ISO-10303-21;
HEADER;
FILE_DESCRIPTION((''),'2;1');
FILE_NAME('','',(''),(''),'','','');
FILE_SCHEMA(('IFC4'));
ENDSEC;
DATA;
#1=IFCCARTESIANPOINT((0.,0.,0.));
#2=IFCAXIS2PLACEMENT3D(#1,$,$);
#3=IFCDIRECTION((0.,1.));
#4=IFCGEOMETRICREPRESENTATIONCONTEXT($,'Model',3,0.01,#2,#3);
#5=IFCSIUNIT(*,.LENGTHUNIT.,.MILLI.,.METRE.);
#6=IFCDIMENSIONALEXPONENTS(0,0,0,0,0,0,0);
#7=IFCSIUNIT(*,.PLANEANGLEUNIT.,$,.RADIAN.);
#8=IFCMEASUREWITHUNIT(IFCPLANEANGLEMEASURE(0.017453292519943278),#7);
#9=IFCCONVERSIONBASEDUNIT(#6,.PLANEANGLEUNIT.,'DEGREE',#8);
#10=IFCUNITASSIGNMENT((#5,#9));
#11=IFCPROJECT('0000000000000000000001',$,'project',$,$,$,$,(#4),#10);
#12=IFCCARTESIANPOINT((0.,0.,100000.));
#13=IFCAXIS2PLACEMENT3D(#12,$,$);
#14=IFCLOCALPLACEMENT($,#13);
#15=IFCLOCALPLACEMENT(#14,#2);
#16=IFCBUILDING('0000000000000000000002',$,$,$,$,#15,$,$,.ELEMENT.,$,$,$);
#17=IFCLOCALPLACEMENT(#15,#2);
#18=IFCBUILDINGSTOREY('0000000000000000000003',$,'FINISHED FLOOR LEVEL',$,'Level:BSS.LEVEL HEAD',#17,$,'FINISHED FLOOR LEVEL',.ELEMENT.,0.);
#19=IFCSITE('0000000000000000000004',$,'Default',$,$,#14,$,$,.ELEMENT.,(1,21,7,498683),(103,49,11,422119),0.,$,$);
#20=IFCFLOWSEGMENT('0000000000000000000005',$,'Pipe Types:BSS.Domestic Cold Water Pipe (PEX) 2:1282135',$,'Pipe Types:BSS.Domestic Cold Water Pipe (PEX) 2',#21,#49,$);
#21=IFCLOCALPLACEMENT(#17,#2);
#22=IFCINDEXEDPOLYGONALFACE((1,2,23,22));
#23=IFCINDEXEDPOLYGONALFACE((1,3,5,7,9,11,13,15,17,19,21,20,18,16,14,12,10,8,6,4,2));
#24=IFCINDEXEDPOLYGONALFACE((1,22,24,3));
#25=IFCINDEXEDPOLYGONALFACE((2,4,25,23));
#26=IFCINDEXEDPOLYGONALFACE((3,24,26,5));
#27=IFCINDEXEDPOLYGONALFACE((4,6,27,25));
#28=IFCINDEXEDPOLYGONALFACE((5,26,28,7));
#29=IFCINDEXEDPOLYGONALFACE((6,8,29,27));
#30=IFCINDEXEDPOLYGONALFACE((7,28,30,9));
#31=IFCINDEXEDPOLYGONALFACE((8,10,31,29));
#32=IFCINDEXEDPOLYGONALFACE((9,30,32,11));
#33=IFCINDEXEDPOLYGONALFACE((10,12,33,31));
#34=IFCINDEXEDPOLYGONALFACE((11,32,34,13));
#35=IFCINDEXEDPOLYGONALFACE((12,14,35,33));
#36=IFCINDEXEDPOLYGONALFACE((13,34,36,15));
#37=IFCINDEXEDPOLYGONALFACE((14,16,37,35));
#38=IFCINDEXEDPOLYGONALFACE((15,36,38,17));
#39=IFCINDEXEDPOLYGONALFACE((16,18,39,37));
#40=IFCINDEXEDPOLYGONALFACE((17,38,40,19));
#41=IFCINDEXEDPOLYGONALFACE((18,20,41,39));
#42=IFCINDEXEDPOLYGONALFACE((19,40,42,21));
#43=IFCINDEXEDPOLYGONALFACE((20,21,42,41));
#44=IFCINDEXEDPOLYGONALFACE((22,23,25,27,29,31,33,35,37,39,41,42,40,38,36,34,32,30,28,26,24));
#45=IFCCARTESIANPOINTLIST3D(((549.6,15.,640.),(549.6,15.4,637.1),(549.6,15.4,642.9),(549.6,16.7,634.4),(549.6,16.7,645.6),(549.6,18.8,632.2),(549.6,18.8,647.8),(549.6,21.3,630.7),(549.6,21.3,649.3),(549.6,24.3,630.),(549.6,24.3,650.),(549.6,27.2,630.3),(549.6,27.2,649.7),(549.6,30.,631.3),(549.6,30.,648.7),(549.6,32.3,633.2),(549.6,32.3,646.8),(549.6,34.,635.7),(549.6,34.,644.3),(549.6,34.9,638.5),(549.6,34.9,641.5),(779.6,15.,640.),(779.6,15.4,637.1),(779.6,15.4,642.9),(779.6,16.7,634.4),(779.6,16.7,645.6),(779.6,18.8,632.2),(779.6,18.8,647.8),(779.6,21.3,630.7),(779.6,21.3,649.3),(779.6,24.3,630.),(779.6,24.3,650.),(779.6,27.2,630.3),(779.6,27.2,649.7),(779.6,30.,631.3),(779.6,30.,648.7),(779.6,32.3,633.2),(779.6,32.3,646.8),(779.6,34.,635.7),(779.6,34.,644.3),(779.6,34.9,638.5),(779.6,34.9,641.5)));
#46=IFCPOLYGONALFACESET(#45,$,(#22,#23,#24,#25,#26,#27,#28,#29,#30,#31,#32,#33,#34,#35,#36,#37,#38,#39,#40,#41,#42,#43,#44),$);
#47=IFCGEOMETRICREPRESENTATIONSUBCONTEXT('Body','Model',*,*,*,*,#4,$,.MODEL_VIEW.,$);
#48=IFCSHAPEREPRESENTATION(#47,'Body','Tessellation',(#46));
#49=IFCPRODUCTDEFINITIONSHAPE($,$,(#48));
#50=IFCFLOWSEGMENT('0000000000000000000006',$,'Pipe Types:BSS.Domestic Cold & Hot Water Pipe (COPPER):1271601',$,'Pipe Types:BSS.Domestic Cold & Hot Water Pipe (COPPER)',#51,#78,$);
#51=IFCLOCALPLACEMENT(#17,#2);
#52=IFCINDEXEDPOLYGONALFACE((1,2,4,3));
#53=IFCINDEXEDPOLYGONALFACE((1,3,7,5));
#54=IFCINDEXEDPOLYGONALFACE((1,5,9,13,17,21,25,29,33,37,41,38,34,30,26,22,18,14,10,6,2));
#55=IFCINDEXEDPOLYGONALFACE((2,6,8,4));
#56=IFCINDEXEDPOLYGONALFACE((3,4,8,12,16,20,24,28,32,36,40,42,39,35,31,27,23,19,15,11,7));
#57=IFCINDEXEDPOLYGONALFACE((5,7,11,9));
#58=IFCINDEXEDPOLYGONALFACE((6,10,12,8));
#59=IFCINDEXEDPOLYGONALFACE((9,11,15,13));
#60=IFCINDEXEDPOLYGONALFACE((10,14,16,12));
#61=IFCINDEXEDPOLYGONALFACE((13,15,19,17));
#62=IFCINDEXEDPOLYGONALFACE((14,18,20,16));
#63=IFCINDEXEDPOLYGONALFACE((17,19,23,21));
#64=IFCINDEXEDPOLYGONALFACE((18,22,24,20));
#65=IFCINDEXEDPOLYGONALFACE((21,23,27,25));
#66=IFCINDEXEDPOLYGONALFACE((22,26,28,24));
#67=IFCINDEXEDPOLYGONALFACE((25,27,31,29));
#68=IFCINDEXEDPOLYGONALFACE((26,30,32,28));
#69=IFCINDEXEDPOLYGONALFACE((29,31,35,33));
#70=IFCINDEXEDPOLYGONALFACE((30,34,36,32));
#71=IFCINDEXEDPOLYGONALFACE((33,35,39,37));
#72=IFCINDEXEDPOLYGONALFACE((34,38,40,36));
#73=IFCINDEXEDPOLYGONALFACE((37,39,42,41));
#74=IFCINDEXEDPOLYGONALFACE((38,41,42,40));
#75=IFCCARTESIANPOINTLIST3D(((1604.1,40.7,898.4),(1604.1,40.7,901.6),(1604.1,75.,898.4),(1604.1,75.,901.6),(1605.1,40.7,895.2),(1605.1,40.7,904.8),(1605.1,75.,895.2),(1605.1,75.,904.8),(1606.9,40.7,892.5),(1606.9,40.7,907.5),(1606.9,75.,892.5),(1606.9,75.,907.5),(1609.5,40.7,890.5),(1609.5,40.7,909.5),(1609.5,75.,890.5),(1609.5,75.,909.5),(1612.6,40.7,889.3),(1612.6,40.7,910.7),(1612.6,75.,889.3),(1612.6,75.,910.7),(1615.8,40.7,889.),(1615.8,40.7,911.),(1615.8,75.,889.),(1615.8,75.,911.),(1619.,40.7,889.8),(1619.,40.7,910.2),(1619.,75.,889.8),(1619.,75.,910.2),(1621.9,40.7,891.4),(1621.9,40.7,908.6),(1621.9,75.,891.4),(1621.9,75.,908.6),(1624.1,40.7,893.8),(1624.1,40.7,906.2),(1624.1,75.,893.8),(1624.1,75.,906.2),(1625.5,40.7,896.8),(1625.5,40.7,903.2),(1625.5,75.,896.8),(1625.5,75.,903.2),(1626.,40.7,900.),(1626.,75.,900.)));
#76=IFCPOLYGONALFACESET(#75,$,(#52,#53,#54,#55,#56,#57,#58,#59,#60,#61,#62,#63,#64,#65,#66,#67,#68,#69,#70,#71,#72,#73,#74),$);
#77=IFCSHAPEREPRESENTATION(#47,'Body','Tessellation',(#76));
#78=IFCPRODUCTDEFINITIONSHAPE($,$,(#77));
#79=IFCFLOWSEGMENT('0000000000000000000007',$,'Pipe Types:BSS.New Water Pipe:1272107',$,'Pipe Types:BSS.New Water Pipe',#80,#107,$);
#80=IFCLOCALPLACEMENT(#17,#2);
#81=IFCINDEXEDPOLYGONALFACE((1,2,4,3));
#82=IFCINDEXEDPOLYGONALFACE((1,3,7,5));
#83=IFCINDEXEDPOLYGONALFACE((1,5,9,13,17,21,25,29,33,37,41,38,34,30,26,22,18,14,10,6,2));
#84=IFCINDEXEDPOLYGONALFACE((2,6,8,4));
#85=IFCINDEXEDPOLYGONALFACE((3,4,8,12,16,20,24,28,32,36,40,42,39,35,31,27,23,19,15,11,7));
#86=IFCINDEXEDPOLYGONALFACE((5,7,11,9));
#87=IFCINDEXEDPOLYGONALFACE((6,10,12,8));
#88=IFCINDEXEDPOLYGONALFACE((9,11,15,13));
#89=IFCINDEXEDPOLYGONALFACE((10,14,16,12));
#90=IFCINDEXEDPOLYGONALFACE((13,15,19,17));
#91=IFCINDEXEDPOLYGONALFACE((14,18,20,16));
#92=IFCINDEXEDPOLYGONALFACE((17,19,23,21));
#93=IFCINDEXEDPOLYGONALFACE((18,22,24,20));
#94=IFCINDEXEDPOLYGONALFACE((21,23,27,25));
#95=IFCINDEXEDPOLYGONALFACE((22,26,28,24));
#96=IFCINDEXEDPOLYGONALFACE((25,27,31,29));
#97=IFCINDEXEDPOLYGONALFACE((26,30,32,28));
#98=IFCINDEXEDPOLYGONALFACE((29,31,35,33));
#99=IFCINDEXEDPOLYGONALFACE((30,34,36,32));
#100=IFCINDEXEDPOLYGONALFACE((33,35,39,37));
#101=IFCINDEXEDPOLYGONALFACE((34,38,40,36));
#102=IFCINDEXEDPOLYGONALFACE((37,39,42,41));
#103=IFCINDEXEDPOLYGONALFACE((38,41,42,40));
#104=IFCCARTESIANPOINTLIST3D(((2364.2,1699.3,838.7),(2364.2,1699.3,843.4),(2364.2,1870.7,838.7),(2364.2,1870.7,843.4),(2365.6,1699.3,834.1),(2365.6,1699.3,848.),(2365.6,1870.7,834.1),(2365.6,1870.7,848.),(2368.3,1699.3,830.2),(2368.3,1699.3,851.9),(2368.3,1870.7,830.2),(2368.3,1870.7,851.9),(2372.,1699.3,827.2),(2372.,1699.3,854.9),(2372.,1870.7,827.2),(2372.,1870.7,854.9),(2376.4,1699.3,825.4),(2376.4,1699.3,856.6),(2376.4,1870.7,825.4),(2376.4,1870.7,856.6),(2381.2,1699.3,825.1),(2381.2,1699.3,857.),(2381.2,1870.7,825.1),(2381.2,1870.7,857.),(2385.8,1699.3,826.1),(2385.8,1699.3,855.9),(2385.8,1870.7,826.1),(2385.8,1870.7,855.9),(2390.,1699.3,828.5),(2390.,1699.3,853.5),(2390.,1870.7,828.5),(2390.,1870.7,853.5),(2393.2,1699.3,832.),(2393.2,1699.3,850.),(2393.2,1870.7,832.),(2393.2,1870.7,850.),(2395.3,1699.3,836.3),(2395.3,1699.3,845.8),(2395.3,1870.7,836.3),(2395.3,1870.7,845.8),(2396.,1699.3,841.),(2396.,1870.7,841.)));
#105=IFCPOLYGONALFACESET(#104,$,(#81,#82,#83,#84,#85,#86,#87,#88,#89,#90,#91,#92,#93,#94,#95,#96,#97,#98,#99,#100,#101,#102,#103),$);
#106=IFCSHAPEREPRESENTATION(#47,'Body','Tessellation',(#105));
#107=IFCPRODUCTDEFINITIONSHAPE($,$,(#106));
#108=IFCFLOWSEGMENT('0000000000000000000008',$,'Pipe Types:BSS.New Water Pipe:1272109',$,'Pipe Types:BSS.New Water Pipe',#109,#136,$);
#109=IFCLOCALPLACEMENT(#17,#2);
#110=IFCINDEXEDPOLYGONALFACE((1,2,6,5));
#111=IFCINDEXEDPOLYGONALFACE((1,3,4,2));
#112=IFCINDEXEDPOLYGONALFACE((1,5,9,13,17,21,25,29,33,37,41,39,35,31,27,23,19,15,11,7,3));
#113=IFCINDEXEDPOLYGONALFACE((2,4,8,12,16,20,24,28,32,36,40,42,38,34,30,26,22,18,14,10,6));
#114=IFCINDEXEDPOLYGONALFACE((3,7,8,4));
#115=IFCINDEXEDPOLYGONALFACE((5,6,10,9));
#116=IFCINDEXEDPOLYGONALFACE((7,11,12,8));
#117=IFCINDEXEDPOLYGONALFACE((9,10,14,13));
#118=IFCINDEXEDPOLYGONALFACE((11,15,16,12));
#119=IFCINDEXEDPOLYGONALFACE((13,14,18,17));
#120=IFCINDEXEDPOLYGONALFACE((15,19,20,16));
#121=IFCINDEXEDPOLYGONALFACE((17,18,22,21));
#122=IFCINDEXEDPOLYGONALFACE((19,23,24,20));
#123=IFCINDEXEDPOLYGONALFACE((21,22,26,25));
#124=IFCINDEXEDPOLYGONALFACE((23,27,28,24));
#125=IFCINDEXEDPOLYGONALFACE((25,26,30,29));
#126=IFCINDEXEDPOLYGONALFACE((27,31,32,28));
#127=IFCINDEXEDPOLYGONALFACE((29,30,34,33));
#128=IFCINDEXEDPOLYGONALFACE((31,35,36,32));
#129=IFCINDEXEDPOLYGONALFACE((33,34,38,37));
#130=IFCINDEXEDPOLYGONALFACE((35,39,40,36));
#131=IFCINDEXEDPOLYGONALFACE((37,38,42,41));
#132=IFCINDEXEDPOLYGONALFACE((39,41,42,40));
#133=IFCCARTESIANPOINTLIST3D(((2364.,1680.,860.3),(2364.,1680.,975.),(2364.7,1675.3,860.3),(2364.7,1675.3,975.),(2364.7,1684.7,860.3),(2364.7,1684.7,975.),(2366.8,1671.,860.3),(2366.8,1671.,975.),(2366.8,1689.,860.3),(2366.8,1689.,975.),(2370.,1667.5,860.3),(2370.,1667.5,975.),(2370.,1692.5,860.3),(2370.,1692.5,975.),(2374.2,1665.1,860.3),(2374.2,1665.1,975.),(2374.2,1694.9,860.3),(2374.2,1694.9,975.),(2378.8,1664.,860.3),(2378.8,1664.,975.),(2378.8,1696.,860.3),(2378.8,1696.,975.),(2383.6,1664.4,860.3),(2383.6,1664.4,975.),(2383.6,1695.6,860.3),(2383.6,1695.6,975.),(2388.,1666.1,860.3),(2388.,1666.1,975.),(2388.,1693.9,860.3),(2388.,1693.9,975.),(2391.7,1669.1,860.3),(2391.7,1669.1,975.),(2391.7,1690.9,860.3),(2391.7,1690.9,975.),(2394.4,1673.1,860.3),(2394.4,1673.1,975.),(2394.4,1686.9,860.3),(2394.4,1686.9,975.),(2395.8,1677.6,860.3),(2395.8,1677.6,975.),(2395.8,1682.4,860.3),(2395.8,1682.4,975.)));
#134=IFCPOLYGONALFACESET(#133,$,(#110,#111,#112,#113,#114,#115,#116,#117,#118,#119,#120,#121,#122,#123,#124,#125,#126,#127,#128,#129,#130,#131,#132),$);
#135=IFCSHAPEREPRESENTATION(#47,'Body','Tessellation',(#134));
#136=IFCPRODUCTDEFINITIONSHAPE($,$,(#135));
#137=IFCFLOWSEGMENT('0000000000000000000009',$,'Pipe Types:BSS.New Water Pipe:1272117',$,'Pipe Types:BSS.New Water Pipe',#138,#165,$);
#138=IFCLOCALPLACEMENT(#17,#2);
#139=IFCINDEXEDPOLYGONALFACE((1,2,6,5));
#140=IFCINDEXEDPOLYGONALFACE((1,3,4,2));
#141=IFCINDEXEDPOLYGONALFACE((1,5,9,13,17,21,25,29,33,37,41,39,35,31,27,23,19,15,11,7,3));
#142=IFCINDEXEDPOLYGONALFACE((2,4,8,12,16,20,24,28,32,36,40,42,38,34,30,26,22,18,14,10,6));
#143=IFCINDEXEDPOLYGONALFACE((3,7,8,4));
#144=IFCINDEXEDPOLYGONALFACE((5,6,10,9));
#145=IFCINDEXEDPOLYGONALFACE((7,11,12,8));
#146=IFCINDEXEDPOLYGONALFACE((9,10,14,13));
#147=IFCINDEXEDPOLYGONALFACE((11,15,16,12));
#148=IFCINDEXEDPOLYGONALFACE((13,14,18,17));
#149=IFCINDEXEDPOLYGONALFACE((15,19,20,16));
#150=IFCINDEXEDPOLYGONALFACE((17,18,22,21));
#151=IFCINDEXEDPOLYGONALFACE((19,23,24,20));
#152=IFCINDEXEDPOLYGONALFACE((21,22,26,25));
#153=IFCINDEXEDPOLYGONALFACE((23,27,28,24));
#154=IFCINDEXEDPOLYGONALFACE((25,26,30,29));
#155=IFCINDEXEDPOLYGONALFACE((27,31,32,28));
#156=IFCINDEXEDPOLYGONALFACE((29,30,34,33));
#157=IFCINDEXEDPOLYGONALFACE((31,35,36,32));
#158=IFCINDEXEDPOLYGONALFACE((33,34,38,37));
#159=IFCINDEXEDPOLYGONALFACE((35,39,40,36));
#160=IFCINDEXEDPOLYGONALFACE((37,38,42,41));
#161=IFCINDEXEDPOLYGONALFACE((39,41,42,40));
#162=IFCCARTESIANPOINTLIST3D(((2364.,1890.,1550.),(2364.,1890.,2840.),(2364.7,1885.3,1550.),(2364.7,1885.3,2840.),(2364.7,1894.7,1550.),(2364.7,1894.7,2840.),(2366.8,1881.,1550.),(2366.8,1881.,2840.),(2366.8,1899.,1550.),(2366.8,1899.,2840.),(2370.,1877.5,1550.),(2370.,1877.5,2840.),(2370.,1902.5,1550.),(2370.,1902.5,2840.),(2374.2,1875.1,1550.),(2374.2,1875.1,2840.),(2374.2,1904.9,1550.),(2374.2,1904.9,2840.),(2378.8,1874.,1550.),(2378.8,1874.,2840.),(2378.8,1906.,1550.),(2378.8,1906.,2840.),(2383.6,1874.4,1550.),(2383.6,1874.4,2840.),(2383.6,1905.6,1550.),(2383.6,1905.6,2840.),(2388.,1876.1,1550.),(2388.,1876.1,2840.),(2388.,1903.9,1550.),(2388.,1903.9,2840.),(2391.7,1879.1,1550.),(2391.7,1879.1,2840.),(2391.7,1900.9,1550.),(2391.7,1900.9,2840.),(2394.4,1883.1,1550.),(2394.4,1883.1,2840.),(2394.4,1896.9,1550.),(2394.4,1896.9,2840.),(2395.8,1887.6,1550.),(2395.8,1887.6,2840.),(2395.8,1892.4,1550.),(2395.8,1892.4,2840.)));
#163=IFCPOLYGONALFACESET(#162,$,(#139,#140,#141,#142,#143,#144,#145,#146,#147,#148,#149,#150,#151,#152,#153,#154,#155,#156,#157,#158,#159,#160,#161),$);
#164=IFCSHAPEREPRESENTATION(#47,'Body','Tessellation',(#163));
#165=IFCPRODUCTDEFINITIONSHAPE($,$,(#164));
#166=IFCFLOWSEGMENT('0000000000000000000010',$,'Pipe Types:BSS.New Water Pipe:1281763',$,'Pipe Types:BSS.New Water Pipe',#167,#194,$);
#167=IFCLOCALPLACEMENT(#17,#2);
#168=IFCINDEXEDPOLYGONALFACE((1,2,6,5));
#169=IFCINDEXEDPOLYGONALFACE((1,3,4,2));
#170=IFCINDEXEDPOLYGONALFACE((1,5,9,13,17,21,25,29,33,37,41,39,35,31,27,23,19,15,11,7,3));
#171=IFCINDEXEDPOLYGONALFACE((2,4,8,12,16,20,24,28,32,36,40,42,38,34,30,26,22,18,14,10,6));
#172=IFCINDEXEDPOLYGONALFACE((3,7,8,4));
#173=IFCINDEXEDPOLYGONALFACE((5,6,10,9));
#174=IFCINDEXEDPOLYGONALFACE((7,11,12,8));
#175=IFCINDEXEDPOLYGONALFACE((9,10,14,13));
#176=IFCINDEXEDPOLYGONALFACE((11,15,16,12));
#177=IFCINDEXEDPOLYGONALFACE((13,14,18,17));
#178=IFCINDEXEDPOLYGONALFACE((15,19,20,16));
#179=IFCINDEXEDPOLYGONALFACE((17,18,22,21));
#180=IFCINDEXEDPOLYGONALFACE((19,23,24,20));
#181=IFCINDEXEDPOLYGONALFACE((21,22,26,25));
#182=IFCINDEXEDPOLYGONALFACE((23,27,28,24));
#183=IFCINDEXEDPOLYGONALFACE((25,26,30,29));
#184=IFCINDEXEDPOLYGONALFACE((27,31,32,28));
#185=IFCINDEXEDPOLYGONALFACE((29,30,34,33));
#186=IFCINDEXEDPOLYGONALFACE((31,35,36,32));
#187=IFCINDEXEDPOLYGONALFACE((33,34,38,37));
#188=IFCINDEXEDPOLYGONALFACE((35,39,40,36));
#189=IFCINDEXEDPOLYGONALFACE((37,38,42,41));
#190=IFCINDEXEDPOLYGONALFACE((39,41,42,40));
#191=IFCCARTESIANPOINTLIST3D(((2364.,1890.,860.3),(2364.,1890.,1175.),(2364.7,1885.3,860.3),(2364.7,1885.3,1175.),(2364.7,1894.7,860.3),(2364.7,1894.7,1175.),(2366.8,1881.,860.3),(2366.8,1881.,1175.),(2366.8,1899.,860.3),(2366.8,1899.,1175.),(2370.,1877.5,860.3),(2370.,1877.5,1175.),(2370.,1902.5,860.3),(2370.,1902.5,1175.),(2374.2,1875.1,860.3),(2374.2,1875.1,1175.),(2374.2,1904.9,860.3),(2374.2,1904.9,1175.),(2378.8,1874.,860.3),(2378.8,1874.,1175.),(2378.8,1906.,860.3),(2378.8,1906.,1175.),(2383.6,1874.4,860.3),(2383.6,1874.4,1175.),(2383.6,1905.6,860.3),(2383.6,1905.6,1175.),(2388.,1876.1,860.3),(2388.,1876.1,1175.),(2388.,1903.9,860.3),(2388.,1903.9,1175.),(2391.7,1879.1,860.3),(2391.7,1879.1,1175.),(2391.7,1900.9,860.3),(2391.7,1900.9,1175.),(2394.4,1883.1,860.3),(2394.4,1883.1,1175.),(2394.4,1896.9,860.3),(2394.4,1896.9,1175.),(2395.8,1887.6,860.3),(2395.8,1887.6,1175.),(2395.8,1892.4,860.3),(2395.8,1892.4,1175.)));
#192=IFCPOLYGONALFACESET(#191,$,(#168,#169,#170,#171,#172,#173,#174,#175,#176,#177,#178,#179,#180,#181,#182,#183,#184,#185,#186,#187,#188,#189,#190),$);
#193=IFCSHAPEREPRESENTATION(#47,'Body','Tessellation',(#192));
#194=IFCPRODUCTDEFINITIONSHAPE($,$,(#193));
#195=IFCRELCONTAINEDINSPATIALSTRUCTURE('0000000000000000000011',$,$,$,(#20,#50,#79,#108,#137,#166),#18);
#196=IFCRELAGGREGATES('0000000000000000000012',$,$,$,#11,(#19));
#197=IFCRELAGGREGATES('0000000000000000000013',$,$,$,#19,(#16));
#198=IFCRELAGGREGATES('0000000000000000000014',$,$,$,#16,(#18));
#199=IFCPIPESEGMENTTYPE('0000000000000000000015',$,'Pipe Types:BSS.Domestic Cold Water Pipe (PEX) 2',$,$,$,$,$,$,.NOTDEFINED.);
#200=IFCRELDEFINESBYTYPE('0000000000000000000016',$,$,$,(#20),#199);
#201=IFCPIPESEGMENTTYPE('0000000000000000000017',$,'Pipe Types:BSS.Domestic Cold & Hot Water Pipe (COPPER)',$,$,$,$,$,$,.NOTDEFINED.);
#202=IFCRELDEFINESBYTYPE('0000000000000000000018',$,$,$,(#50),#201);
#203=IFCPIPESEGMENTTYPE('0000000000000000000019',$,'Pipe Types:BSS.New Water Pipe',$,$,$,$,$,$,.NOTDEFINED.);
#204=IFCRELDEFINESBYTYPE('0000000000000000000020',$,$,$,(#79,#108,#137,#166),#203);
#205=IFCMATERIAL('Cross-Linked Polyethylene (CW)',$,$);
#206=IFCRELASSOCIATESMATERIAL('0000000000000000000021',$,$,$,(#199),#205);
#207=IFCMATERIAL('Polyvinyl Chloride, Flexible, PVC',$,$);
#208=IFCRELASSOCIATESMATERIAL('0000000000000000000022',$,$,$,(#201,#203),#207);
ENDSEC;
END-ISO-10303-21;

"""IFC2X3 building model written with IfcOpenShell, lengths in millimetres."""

from ifc_helpers import new_model, entity, si_unit, converted_unit, direction, frame, frame_2d, origin, origin_2d_with_axis, place, context, subcontext, project, spatial, circle, extrude, material, type_object, element, save


model = new_model("IFC2X3")

# Units and contexts
model_context = context("Model", 3, precision=0.01, world=origin(), true_north=direction((0.0, 1.0)))
body_context = subcontext(model_context, "Body", "Model", "MODEL_VIEW")
ifc_project = project(units=[si_unit("LENGTHUNIT", "METRE", prefix="MILLI"), converted_unit("PLANEANGLEUNIT", "DEGREE", entity("IfcPlaneAngleMeasure", 0.017453292519943278), si_unit("PLANEANGLEUNIT", "RADIAN"), dimensions=[0, 0, 0, 0, 0, 0, 0])], contexts=[model_context])

# Site, building, storey
site_placement = place(None, frame((0.0, 0.0, 100000.0)))
site = spatial("IfcSite", under=ifc_project, at=site_placement, Name="Default", CompositionType="ELEMENT", RefLatitude=(1, 21, 7, 498683), RefLongitude=(103, 49, 11, 422119), RefElevation=0.0)
building_placement = place(site_placement, origin())
building = spatial("IfcBuilding", under=site, at=building_placement, CompositionType="ELEMENT")
storey_placement = place(building_placement, origin())
storey = spatial("IfcBuildingStorey", under=building, at=storey_placement, Name="FINISHED FLOOR LEVEL", ObjectType="Level:BSS.LEVEL HEAD", LongName="FINISHED FLOOR LEVEL", CompositionType="ELEMENT", Elevation=0.0)

# Flow segments
ifc_material_1 = material(Name="Cross-Linked Polyethylene (CW)")
pipe_segment_type_1 = type_object("IfcPipeSegmentType", Name="Pipe Types:BSS.Domestic Cold Water Pipe (PEX) 2", PredefinedType="NOTDEFINED", material=ifc_material_1)
flow_segment_1_placement = place(storey_placement, origin())
element("IfcFlowSegment", 1, at=flow_segment_1_placement, inside=storey, type_object=pipe_segment_type_1, Name="Pipe Types:BSS.Domestic Cold Water Pipe (PEX) 2:1282135", ObjectType="Pipe Types:BSS.Domestic Cold Water Pipe (PEX) 2", context=body_context, shape_type="SweptSolid", body=[
    extrude(circle(Radius=10.0, at=frame_2d((0.0, 0.0), x_axis=(1.0, 0.0))), frame((549.6, 25.0, 640.0), z_axis=(1.0, 0.0, 0.0), x_axis=(0.0, -1.0, 0.0)), (0.0, 0.0, 1.0), 230.0),
])
ifc_material_2 = material(Name="Polyvinyl Chloride, Flexible, PVC")
pipe_segment_type_2 = type_object("IfcPipeSegmentType", Name="Pipe Types:BSS.Domestic Cold & Hot Water Pipe (COPPER)", PredefinedType="NOTDEFINED", material=ifc_material_2)
flow_segment_2_placement = place(storey_placement, origin())
element("IfcFlowSegment", 2, at=flow_segment_2_placement, inside=storey, type_object=pipe_segment_type_2, Name="Pipe Types:BSS.Domestic Cold & Hot Water Pipe (COPPER):1271601", ObjectType="Pipe Types:BSS.Domestic Cold & Hot Water Pipe (COPPER)", context=body_context, shape_type="SweptSolid", body=[
    extrude(circle(Radius=11.0, at=origin_2d_with_axis()), frame((1615.0, 40.7, 900.0), z_axis=(0.0, 1.0, 0.0), x_axis=(1.0, 0.0, 0.0)), (0.0, 0.0, 1.0), 34.3),
])
pipe_segment_type_3 = type_object("IfcPipeSegmentType", Name="Pipe Types:BSS.New Water Pipe", PredefinedType="NOTDEFINED", material=ifc_material_2)
flow_segment_3_placement = place(storey_placement, origin())
element("IfcFlowSegment", 3, at=flow_segment_3_placement, inside=storey, type_object=pipe_segment_type_3, Name="Pipe Types:BSS.New Water Pipe:1272107", ObjectType="Pipe Types:BSS.New Water Pipe", context=body_context, shape_type="SweptSolid", body=[
    extrude(circle(Radius=16.0, at=origin_2d_with_axis()), frame((2380.0, 1699.3, 841.0), z_axis=(0.0, 1.0, 0.0), x_axis=(1.0, 0.0, 0.0)), (0.0, 0.0, 1.0), 171.4),
])
flow_segment_4_placement = place(storey_placement, origin())
element("IfcFlowSegment", 4, at=flow_segment_4_placement, inside=storey, type_object=pipe_segment_type_3, Name="Pipe Types:BSS.New Water Pipe:1272109", ObjectType="Pipe Types:BSS.New Water Pipe", context=body_context, shape_type="SweptSolid", body=[
    extrude(circle(Radius=16.0, at=frame_2d((0.0, 0.0), x_axis=(1.0, 0.0))), frame((2380.0, 1680.0, 860.3), z_axis=(0.0, 0.0, 1.0), x_axis=(-1.0, 0.0, 0.0)), (0.0, 0.0, 1.0), 114.7),
])
flow_segment_5_placement = place(storey_placement, origin())
element("IfcFlowSegment", 5, at=flow_segment_5_placement, inside=storey, type_object=pipe_segment_type_3, Name="Pipe Types:BSS.New Water Pipe:1272117", ObjectType="Pipe Types:BSS.New Water Pipe", context=body_context, shape_type="SweptSolid", body=[
    extrude(circle(Radius=16.0, at=frame_2d((0.0, 0.0), x_axis=(1.0, 0.0))), frame((2380.0, 1890.0, 1550.0), z_axis=(0.0, 0.0, 1.0), x_axis=(-1.0, 0.0, 0.0)), (0.0, 0.0, 1.0), 1290.0),
])
flow_segment_6_placement = place(storey_placement, origin())
element("IfcFlowSegment", 6, at=flow_segment_6_placement, inside=storey, type_object=pipe_segment_type_3, Name="Pipe Types:BSS.New Water Pipe:1281763", ObjectType="Pipe Types:BSS.New Water Pipe", context=body_context, shape_type="SweptSolid", body=[
    extrude(circle(Radius=16.0, at=origin_2d_with_axis()), frame((2380.0, 1890.0, 860.3), z_axis=(0.0, 0.0, 1.0), x_axis=(-1.0, 0.0, 0.0)), (0.0, 0.0, 1.0), 314.7),
])

save(model, "model.ifc")
